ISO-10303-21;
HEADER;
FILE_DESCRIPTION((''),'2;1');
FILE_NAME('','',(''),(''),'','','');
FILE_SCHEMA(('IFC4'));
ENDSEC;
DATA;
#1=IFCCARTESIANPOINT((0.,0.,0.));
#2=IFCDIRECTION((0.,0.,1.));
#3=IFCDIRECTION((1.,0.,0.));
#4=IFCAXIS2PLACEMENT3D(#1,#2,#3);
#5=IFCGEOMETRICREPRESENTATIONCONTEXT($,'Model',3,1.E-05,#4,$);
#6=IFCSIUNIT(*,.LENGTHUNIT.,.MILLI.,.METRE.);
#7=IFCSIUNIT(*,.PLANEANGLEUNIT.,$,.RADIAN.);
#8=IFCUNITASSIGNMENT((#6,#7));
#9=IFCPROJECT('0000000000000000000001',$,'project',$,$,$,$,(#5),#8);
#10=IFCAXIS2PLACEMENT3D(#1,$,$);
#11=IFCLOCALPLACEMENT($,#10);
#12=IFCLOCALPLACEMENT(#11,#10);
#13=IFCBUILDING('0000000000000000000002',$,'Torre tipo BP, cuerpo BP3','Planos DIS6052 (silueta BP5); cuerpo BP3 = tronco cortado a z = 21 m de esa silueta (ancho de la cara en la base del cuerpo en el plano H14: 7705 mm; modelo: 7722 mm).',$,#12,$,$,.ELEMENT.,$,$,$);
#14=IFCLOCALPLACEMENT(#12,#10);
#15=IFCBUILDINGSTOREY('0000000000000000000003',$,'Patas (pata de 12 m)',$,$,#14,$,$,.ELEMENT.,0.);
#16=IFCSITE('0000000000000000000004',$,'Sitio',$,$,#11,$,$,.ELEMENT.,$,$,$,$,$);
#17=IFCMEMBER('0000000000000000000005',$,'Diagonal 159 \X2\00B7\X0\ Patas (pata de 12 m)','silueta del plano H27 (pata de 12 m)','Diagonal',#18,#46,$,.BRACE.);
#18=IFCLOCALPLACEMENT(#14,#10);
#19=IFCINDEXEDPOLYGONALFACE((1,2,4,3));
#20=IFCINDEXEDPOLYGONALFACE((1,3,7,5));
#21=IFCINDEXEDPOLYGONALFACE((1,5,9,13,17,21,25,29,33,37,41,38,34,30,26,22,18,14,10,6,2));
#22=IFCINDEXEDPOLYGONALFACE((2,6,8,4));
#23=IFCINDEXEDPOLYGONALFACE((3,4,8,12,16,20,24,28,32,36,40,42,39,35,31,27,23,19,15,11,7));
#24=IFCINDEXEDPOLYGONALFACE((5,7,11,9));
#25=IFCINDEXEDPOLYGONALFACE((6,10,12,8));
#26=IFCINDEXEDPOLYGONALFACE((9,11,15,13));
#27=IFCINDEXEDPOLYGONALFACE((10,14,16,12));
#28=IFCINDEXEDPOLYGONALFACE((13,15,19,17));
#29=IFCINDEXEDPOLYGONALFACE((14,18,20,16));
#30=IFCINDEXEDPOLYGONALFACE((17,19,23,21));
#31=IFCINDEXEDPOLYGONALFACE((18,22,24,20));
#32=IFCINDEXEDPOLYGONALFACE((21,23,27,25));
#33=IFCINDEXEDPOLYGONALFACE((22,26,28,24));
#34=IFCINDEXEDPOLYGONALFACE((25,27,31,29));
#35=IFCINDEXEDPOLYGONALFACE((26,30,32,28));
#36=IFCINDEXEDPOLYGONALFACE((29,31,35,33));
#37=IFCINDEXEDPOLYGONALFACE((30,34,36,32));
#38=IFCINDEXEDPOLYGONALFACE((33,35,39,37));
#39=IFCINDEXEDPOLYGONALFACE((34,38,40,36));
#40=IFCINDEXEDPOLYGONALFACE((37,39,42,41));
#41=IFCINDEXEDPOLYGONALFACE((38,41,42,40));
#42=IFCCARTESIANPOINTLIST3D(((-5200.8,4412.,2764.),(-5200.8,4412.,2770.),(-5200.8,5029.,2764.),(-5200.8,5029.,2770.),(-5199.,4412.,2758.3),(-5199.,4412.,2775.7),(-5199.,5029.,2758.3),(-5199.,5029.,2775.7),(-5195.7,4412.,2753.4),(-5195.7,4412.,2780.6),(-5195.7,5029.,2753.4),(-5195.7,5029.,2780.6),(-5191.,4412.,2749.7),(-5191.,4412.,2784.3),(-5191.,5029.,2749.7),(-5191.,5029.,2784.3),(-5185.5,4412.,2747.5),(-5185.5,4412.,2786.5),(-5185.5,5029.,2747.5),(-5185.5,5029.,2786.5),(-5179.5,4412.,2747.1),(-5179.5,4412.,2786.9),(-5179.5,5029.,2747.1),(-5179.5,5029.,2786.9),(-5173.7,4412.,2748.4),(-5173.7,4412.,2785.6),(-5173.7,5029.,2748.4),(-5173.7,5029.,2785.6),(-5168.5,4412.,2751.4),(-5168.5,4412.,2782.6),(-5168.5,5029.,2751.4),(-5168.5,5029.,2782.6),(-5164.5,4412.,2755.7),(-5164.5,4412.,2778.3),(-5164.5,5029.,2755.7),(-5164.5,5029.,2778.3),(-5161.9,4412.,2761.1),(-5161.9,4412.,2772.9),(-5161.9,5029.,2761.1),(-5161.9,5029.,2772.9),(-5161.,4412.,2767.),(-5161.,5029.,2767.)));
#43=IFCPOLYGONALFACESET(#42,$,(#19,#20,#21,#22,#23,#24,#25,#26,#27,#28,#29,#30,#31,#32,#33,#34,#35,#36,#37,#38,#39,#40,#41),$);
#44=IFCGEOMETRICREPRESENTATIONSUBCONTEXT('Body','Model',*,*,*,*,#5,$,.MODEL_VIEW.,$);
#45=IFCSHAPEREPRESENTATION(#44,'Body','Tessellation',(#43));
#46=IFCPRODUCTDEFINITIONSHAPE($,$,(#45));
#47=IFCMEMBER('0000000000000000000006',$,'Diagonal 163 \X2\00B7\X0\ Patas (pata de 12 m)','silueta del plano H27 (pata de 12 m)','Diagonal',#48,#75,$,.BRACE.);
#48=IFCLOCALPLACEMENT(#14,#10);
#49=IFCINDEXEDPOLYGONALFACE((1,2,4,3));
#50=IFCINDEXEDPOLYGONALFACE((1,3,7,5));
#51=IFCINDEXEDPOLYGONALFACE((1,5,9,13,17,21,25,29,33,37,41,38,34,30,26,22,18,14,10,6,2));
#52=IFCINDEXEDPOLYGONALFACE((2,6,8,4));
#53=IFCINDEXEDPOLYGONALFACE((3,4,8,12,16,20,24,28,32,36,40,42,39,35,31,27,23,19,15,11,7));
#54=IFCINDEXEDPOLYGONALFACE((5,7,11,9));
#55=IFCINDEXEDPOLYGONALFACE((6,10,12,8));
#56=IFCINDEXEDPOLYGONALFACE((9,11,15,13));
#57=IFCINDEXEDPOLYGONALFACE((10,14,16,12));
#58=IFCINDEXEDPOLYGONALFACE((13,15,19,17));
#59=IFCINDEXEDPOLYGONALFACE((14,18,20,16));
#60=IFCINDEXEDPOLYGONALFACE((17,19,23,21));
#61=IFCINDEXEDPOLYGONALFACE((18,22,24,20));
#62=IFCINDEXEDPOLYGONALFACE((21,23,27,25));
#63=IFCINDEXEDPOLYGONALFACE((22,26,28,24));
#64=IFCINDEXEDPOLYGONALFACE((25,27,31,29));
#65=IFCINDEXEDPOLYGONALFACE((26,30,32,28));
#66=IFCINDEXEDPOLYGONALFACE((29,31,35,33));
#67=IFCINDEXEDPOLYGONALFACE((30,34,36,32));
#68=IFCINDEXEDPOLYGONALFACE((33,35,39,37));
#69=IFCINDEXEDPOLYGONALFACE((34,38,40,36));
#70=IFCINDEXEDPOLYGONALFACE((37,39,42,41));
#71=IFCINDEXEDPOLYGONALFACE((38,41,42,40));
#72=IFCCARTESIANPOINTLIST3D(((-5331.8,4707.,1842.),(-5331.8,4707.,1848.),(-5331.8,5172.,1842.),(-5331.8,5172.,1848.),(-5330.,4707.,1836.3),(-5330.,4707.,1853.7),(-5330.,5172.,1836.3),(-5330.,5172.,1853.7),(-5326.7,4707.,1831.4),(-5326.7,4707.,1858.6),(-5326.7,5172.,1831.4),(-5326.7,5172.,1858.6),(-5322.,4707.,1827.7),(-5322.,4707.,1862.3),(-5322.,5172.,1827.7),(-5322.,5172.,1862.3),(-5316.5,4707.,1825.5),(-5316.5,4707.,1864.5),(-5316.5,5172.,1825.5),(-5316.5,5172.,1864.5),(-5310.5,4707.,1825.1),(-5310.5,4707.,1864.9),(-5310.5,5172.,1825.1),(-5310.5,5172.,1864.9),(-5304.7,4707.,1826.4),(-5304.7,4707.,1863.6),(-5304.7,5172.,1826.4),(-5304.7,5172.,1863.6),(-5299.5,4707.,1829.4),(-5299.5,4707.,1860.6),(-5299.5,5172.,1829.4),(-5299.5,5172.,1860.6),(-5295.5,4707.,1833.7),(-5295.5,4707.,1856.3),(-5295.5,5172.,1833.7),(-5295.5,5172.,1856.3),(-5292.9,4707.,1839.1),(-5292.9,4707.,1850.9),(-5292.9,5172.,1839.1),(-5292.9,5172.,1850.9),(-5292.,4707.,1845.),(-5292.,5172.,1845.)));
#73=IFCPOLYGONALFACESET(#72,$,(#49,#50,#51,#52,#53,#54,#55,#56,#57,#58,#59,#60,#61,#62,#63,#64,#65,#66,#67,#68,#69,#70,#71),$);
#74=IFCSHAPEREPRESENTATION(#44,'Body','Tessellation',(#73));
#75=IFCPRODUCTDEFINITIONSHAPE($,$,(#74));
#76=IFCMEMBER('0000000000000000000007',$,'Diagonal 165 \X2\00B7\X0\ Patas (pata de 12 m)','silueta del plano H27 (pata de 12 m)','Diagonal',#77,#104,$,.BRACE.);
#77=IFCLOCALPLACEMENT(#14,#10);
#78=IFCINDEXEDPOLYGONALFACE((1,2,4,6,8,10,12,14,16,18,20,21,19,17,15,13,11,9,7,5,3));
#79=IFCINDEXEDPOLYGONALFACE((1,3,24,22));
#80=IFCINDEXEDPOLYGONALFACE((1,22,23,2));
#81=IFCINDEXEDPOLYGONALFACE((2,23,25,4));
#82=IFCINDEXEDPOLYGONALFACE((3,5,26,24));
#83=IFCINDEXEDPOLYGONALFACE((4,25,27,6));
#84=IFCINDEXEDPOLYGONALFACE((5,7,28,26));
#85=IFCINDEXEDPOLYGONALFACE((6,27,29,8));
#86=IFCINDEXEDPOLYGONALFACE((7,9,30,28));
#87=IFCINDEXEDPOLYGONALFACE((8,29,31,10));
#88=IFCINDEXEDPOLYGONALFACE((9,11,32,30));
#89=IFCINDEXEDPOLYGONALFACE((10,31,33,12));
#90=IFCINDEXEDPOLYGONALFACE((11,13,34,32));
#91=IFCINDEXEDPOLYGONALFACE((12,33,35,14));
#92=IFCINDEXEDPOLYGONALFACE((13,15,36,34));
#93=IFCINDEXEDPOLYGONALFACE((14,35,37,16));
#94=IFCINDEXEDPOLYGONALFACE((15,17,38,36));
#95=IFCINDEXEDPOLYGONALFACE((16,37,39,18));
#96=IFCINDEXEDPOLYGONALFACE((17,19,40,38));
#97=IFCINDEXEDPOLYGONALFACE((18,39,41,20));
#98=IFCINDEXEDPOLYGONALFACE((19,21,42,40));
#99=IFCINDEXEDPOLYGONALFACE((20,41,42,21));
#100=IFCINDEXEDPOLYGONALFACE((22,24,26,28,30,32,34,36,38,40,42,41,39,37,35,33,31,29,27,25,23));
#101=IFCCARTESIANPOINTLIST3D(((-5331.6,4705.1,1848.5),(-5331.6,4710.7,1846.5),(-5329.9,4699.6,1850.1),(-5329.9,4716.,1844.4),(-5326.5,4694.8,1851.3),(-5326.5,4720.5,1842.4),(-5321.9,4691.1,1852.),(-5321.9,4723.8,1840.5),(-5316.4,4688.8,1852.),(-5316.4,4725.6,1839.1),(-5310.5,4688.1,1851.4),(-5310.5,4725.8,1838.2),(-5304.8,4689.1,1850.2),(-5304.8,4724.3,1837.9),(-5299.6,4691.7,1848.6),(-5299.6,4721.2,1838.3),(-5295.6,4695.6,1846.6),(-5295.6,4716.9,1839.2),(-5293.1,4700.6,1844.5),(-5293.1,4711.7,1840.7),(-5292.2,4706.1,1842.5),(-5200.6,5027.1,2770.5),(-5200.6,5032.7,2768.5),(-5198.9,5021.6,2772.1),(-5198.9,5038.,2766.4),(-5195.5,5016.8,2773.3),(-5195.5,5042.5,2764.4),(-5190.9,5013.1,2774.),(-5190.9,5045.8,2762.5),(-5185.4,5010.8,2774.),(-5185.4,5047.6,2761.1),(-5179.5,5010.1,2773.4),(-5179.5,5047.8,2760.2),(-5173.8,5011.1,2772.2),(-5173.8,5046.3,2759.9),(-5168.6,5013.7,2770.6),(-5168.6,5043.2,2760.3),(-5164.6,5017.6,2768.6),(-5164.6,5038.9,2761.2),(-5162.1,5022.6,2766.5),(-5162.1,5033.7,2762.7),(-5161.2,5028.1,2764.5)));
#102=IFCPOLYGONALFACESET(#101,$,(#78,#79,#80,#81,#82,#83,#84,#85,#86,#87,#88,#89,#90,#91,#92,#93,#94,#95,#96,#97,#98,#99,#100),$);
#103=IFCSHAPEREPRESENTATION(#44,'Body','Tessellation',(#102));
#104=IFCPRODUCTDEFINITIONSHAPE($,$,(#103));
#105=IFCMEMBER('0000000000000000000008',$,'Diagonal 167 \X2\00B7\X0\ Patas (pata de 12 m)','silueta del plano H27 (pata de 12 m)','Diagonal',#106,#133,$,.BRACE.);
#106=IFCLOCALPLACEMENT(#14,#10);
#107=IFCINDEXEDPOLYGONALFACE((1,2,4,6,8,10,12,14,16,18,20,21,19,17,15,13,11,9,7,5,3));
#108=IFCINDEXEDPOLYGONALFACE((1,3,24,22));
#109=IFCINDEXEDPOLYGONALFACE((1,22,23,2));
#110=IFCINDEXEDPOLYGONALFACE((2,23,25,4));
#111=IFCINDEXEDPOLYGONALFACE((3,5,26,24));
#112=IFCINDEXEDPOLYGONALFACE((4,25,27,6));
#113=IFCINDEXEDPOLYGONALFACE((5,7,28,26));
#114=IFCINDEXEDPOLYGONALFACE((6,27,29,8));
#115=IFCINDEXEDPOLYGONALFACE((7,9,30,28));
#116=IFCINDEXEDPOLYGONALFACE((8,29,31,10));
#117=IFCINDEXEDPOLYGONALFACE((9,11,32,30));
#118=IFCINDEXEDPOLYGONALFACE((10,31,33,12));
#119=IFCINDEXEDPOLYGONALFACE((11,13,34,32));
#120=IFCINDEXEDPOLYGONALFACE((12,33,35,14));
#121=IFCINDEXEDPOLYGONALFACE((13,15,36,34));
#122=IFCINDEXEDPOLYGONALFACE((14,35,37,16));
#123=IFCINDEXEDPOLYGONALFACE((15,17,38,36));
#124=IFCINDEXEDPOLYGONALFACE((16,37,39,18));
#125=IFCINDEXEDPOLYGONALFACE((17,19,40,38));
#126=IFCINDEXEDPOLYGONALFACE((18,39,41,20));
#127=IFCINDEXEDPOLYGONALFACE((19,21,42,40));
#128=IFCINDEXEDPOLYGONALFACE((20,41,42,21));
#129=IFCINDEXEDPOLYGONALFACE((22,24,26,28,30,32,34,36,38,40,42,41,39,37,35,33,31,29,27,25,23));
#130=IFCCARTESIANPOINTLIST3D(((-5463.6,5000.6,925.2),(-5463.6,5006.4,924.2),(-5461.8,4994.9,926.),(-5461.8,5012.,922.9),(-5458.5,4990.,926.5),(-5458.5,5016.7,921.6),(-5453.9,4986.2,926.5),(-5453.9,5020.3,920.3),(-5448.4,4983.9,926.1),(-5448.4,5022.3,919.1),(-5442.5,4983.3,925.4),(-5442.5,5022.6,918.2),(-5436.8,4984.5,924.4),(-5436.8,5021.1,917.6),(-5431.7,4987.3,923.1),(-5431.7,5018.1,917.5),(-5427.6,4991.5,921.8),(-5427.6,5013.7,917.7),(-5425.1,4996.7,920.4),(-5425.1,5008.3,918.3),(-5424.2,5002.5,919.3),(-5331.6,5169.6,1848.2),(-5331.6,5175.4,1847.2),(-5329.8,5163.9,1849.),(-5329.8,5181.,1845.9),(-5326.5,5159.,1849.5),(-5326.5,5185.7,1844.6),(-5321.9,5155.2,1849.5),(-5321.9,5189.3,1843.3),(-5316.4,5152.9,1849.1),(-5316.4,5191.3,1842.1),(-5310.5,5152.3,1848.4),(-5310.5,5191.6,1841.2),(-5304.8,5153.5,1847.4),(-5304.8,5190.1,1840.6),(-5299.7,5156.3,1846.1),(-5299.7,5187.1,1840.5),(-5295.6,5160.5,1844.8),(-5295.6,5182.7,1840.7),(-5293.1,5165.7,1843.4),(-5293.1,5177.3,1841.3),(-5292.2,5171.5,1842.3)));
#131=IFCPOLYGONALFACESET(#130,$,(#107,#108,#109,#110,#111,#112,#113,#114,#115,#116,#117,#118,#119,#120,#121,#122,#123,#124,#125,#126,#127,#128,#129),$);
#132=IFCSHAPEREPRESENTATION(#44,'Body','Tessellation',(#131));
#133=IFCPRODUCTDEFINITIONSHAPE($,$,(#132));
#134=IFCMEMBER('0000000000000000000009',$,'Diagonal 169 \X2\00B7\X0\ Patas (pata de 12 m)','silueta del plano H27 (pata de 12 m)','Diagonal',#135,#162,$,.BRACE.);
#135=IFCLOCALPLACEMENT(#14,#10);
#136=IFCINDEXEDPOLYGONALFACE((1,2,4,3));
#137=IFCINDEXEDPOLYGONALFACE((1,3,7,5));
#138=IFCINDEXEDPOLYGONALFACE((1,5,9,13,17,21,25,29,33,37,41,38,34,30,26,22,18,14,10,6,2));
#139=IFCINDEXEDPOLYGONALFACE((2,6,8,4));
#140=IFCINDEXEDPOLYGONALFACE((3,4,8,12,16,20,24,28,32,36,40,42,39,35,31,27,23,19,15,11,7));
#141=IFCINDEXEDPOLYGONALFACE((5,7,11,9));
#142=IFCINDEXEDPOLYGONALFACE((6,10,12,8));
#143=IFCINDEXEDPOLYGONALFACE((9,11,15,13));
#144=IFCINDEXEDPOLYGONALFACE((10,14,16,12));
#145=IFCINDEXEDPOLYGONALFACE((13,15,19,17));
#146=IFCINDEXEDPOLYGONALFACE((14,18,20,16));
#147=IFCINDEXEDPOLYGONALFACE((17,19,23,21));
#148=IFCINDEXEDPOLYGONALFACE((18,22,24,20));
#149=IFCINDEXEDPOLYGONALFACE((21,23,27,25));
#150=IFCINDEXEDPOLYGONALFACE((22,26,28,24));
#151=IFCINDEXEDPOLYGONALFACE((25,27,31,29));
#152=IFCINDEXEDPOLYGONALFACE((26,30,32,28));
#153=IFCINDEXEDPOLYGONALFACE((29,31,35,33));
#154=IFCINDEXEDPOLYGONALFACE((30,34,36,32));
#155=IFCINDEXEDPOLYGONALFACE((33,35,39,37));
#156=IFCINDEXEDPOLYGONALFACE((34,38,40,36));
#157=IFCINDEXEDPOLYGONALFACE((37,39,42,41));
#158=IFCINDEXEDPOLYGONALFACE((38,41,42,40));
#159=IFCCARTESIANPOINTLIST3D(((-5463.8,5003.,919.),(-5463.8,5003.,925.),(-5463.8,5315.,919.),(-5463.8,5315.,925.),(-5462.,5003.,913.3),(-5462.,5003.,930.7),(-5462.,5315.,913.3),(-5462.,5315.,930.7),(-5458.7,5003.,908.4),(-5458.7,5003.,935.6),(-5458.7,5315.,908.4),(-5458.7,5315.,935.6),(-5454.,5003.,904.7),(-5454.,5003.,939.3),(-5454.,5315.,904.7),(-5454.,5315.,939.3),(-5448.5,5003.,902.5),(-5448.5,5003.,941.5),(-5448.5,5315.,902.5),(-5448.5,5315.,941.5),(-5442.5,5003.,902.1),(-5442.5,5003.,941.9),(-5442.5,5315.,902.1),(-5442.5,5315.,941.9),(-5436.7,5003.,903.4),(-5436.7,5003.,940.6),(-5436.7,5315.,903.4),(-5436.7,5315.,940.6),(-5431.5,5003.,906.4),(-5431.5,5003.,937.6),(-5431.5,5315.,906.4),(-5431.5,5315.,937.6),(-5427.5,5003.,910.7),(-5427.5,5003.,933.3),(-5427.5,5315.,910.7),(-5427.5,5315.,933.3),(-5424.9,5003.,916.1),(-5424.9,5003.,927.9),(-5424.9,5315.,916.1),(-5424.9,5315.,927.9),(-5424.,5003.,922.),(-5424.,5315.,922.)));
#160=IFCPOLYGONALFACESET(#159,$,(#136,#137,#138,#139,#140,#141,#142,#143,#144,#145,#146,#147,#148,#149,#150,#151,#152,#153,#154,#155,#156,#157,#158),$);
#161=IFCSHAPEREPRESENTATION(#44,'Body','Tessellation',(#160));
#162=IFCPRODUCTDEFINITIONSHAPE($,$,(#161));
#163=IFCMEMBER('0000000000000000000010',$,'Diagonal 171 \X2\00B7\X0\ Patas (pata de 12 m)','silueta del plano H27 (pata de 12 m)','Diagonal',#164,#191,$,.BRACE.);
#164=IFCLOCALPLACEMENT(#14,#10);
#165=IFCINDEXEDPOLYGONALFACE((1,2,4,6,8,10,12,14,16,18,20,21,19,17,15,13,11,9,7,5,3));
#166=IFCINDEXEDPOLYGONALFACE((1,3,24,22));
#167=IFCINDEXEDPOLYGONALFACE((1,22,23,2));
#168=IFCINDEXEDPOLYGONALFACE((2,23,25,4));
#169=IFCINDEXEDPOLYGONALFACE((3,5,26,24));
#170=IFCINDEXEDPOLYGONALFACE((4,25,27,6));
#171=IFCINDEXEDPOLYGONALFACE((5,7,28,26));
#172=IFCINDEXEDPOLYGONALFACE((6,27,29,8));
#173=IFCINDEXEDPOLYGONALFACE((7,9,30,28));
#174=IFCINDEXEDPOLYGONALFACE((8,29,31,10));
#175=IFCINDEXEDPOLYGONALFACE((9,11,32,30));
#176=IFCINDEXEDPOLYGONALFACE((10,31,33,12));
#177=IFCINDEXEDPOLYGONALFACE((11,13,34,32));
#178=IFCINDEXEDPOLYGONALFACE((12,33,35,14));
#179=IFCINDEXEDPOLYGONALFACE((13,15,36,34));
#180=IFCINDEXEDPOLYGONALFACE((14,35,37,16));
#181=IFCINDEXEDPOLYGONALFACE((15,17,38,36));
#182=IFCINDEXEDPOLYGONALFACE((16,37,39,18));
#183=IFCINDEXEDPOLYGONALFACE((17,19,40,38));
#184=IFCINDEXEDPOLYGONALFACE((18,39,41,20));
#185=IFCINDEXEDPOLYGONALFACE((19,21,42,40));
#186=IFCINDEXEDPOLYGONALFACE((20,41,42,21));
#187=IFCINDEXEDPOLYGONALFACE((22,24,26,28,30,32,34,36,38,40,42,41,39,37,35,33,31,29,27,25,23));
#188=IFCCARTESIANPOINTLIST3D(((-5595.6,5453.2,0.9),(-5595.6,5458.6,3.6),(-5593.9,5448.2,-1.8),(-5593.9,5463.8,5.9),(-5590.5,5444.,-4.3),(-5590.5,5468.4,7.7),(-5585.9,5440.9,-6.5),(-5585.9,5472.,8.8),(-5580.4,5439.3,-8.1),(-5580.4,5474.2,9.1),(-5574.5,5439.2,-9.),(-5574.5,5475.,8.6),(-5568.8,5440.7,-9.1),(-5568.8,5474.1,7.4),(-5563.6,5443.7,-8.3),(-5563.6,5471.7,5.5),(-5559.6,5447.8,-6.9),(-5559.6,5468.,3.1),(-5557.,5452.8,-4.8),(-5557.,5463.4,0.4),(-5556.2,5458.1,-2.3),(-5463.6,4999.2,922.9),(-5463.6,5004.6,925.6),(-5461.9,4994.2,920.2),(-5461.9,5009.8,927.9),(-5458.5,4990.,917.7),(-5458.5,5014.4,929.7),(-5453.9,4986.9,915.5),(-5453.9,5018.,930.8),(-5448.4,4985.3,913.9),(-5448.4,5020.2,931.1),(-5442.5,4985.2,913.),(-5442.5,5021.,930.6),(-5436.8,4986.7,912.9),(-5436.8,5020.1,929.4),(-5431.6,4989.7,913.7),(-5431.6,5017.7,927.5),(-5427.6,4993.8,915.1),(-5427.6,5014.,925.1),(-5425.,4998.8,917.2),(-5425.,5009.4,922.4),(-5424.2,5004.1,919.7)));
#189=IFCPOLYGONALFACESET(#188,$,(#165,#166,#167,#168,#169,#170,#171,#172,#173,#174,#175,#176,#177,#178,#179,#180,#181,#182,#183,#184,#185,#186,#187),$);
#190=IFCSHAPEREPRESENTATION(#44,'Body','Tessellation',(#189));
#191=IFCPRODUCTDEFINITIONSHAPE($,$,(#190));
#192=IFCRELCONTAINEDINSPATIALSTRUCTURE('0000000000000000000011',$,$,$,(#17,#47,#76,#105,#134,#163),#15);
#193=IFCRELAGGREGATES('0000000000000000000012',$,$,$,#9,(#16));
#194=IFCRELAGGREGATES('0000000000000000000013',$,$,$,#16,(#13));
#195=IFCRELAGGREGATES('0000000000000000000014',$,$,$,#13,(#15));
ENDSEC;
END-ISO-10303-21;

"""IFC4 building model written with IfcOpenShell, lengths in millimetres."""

from ifc_helpers import new_model, si_unit, frame, origin, origin_with_axes, place, context, subcontext, project, spatial, circle, extrude, element, save


model = new_model("IFC4")

# Units and contexts
model_context = context("Model", 3, precision=1e-05, world=origin_with_axes())
body_context = subcontext(model_context, "Body", "Model", "MODEL_VIEW")
ifc_project = project(units=[si_unit("LENGTHUNIT", "METRE", prefix="MILLI"), si_unit("PLANEANGLEUNIT", "RADIAN")], contexts=[model_context])

# Site, building, storey
site_placement = place(None, origin())
site = spatial("IfcSite", under=ifc_project, at=site_placement, Name="Sitio", CompositionType="ELEMENT")
building_placement = place(site_placement, origin())
building = spatial("IfcBuilding", under=site, at=building_placement, Name="Torre tipo BP, cuerpo BP3", Description="Planos DIS6052 (silueta BP5); cuerpo BP3 = tronco cortado a z = 21 m de esa silueta (ancho de la cara en la base del cuerpo en el plano H14: 7705 mm; modelo: 7722 mm).", CompositionType="ELEMENT")
storey_placement = place(building_placement, origin())
storey = spatial("IfcBuildingStorey", under=building, at=storey_placement, Name="Patas (pata de 12 m)", CompositionType="ELEMENT", Elevation=0.0)

# Members
member_1_placement = place(storey_placement, frame((-5181.0, 5029.0, 2767.0), z_axis=(0.0, -1.0, 0.0), x_axis=(1.0, 0.0, 0.0)))
element("IfcMember", 1, at=member_1_placement, inside=storey, Name="Diagonal 159 · Patas (pata de 12 m)", Description="silueta del plano H27 (pata de 12 m)", ObjectType="Diagonal", PredefinedType="BRACE", context=body_context, shape_type="SweptSolid", body=[
    extrude(circle(Radius=20.0), None, (0.0, 0.0, 1.0), 617.0),
])
member_2_placement = place(storey_placement, frame((-5312.0, 5172.0, 1845.0), z_axis=(0.0, -1.0, 0.0), x_axis=(1.0, 0.0, 0.0)))
element("IfcMember", 2, at=member_2_placement, inside=storey, Name="Diagonal 163 · Patas (pata de 12 m)", Description="silueta del plano H27 (pata de 12 m)", ObjectType="Diagonal", PredefinedType="BRACE", context=body_context, shape_type="SweptSolid", body=[
    extrude(circle(Radius=20.0), None, (0.0, 0.0, 1.0), 465.0),
])
member_3_placement = place(storey_placement, frame((-5312.0, 4707.0, 1845.0), z_axis=(0.132947, 0.326785, 0.935701), x_axis=(0.991123, -0.043834, -0.125513)))
element("IfcMember", 3, at=member_3_placement, inside=storey, Name="Diagonal 165 · Patas (pata de 12 m)", Description="silueta del plano H27 (pata de 12 m)", ObjectType="Diagonal", PredefinedType="BRACE", context=body_context, shape_type="SweptSolid", body=[
    extrude(circle(Radius=20.0), None, (0.0, 0.0, 1.0), 985.4),
])
member_4_placement = place(storey_placement, frame((-5444.0, 5003.0, 922.0), z_axis=(0.139302, 0.178348, 0.974057), x_axis=(0.99025, -0.025089, -0.137024)))
element("IfcMember", 4, at=member_4_placement, inside=storey, Name="Diagonal 167 · Patas (pata de 12 m)", Description="silueta del plano H27 (pata de 12 m)", ObjectType="Diagonal", PredefinedType="BRACE", context=body_context, shape_type="SweptSolid", body=[
    extrude(circle(Radius=20.0), None, (0.0, 0.0, 1.0), 947.6),
])
member_5_placement = place(storey_placement, frame((-5444.0, 5315.0, 922.0), z_axis=(0.0, -1.0, 0.0), x_axis=(1.0, 0.0, 0.0)))
element("IfcMember", 5, at=member_5_placement, inside=storey, Name="Diagonal 169 · Patas (pata de 12 m)", Description="silueta del plano H27 (pata de 12 m)", ObjectType="Diagonal", PredefinedType="BRACE", context=body_context, shape_type="SweptSolid", body=[
    extrude(circle(Radius=20.0), None, (0.0, 0.0, 1.0), 312.0),
])
member_6_placement = place(storey_placement, frame((-5576.0, 5457.0, 0.0), z_axis=(0.127394, -0.438157, 0.889825), x_axis=(0.991852, 0.056277, -0.114289)))
element("IfcMember", 6, at=member_6_placement, inside=storey, Name="Diagonal 171 · Patas (pata de 12 m)", Description="silueta del plano H27 (pata de 12 m)", ObjectType="Diagonal", PredefinedType="BRACE", context=body_context, shape_type="SweptSolid", body=[
    extrude(circle(Radius=20.0), None, (0.0, 0.0, 1.0), 1036.2),
])

save(model, "model.ifc")
